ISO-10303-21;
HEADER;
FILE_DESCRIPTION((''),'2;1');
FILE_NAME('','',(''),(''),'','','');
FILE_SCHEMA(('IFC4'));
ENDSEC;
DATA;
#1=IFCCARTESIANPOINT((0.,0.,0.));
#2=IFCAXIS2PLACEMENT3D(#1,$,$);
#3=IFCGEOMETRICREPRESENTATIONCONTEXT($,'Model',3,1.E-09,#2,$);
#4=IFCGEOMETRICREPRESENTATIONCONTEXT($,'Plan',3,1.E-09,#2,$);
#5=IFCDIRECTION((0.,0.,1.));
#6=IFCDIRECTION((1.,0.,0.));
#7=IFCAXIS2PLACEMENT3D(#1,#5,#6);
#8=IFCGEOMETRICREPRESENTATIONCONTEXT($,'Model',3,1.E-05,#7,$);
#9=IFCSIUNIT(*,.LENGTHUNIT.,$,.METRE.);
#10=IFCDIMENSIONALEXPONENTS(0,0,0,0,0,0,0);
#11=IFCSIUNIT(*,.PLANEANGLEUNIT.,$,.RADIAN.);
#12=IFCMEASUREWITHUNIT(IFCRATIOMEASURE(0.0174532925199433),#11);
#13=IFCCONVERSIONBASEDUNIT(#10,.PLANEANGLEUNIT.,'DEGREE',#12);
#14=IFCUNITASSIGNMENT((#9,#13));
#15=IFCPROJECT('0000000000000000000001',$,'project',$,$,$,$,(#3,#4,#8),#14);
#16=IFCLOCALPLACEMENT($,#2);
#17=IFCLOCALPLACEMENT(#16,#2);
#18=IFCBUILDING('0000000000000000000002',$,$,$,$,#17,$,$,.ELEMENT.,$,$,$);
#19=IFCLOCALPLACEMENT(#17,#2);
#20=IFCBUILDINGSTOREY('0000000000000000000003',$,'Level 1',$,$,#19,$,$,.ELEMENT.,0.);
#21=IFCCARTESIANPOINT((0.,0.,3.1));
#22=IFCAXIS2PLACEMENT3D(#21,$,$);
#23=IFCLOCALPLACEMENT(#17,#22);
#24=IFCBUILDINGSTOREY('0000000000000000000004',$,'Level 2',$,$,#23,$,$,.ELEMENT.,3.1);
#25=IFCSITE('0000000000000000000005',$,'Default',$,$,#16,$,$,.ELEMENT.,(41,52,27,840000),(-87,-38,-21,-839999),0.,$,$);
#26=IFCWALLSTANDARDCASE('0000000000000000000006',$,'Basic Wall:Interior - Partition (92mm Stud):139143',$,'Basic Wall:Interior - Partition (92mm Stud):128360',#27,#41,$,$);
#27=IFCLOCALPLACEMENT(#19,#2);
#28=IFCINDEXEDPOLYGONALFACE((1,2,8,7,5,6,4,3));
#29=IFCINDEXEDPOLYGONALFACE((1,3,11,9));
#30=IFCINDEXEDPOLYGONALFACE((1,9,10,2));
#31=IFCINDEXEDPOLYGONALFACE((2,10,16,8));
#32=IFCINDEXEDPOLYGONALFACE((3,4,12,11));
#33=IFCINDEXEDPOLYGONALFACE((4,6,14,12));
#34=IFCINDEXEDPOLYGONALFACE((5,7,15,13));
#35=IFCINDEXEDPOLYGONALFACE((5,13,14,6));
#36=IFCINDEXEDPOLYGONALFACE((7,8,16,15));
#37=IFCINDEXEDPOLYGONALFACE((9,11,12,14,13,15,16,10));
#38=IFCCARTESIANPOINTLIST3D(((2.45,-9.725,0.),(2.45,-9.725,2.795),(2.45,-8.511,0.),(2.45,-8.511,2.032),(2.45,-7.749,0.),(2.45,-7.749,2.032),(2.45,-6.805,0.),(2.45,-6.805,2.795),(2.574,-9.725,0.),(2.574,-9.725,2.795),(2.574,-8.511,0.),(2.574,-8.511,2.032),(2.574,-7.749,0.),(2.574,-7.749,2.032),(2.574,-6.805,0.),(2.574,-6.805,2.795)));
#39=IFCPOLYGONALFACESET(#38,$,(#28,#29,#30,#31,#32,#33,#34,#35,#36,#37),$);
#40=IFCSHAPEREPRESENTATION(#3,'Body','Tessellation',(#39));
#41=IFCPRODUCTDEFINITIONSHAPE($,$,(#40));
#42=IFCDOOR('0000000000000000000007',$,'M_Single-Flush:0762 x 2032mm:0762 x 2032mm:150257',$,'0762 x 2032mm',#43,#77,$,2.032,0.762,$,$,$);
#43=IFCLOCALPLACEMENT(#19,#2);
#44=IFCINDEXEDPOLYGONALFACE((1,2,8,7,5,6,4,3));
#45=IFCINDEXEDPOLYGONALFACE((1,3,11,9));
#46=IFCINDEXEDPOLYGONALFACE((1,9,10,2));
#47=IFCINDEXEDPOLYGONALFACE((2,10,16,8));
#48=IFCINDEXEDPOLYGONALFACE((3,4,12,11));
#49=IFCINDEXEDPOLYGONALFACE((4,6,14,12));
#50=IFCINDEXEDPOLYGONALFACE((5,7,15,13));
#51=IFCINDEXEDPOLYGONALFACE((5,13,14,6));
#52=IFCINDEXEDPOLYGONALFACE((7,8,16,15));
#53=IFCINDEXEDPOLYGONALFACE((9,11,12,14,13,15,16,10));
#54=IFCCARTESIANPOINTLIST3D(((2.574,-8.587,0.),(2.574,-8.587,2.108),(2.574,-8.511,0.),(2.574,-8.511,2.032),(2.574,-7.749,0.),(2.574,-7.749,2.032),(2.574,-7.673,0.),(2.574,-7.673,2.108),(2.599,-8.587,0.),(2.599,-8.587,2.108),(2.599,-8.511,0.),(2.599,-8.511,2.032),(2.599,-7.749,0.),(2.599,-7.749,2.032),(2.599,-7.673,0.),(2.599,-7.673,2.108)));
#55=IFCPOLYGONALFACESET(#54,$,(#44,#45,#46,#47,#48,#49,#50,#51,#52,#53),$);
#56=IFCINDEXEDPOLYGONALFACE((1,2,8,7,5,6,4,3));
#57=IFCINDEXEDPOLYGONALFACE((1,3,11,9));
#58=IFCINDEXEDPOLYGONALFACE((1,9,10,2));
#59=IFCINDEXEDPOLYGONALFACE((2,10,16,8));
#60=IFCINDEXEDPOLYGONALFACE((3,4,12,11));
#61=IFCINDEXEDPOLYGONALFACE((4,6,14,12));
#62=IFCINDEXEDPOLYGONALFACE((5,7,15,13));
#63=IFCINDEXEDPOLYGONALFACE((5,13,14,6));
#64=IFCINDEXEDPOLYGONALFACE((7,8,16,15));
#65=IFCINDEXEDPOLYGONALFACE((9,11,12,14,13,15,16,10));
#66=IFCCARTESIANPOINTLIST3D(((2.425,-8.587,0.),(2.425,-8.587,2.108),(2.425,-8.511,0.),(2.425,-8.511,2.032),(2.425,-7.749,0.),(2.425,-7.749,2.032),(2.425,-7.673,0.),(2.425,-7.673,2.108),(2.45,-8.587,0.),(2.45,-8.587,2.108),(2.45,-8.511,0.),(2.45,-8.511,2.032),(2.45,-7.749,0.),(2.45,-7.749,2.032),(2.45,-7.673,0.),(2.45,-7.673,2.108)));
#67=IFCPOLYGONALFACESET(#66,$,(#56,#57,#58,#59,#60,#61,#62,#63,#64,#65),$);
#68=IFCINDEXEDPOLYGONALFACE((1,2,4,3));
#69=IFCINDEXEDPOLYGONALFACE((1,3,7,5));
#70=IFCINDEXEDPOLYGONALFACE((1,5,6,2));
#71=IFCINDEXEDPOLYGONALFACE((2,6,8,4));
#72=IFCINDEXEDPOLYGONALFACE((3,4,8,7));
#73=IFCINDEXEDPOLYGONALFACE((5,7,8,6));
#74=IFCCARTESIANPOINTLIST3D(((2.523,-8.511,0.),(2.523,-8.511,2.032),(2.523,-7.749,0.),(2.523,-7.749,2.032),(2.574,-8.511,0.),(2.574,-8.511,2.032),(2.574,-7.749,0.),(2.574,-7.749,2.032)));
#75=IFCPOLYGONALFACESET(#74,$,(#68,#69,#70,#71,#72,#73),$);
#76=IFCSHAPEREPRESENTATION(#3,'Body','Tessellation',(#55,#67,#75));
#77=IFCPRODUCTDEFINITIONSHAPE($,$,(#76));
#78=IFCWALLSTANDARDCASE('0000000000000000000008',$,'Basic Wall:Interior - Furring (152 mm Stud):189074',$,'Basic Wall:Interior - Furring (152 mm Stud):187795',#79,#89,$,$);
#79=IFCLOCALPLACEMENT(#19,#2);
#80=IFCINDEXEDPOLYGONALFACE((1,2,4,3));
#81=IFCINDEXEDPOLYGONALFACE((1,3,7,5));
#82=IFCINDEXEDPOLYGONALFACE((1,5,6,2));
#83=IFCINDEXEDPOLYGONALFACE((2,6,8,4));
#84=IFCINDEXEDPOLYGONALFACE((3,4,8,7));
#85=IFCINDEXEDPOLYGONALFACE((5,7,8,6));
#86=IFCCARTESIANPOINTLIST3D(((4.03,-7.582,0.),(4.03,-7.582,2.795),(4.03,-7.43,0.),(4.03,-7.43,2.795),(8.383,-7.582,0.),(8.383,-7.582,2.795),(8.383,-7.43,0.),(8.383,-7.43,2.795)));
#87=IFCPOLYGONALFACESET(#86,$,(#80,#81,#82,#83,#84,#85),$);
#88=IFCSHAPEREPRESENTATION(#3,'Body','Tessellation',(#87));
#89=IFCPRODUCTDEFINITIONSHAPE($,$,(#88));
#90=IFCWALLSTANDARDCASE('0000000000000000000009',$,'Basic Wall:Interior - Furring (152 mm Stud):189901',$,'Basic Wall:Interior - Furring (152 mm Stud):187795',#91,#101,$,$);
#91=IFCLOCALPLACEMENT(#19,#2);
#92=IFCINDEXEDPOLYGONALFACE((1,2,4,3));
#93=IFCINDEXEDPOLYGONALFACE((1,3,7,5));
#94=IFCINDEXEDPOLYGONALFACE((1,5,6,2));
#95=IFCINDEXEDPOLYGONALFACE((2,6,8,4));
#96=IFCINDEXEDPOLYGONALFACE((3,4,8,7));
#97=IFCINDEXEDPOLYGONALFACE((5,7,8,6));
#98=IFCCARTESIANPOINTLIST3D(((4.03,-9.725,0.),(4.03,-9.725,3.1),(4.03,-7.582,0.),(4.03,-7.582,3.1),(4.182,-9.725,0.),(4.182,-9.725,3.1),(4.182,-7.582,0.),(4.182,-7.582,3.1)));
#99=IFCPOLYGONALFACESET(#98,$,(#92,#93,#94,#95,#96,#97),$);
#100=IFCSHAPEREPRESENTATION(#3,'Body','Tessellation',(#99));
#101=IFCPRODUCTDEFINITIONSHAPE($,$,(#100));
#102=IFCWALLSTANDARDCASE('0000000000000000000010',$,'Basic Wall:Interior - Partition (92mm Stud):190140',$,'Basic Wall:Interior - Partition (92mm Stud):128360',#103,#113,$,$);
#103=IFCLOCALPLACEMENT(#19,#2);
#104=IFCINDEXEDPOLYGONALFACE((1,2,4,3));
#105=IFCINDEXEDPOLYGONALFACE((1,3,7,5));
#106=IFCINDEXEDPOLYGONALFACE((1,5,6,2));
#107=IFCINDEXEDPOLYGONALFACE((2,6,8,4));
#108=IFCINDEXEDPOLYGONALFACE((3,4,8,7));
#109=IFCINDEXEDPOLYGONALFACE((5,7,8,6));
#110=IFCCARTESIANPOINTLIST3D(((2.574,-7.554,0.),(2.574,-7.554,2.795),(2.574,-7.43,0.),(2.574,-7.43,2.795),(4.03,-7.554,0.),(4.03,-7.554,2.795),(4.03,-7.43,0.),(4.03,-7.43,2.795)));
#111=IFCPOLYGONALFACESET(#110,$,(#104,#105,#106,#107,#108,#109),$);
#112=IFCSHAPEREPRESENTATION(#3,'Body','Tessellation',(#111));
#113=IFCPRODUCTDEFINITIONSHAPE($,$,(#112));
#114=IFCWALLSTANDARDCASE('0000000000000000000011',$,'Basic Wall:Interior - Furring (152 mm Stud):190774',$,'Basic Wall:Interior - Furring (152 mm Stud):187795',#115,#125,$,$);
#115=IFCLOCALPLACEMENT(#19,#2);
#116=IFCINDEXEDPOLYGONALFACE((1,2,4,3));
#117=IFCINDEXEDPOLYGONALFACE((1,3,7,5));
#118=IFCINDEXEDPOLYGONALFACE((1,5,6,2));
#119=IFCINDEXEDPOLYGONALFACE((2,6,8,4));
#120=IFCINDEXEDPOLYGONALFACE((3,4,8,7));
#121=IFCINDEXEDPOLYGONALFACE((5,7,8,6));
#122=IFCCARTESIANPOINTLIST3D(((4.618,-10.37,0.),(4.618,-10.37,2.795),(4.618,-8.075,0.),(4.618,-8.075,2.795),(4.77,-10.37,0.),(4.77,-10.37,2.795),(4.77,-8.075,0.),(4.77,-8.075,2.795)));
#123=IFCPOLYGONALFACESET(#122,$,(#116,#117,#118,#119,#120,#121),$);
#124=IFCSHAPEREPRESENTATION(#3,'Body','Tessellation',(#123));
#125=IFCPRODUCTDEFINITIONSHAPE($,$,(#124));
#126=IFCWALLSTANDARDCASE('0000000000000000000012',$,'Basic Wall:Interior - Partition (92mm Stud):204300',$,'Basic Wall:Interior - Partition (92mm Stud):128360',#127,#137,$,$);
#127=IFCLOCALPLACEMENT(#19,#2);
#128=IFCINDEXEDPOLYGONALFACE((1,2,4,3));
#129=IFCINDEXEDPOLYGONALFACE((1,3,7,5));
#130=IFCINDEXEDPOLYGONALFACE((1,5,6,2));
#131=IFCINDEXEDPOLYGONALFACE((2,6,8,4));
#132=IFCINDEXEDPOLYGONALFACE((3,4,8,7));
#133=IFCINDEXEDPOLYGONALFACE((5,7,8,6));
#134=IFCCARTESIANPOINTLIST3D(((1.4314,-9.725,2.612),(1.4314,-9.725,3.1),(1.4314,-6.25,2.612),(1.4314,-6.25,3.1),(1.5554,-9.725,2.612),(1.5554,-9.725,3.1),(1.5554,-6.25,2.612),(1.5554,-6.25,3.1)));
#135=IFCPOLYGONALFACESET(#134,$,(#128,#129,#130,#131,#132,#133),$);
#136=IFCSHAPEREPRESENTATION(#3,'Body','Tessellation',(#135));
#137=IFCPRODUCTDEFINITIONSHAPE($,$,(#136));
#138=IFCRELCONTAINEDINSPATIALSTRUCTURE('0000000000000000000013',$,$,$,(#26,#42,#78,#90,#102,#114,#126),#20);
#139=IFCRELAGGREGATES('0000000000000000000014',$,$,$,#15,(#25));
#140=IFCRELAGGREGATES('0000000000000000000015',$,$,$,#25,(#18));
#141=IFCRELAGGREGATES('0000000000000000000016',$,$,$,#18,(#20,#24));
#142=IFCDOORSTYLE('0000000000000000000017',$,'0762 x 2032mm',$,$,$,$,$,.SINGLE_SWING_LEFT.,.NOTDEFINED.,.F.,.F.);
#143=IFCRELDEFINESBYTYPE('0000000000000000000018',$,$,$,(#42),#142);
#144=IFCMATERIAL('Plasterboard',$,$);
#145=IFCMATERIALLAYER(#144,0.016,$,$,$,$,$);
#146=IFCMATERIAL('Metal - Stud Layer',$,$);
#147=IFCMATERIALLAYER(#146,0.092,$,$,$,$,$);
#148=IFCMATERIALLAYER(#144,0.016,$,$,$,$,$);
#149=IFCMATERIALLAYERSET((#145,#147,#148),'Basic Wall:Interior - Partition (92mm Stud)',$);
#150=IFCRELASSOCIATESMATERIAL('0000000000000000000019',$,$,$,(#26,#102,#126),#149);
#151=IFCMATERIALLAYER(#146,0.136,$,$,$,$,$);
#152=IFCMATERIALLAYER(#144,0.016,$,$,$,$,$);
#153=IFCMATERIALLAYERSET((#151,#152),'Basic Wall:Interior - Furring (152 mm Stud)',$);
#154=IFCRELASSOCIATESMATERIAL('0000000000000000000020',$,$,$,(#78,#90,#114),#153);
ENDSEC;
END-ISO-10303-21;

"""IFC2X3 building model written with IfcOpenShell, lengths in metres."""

from ifc_helpers import new_model, entity, si_unit, converted_unit, frame, frame_2d, origin, origin_with_axes, origin_2d_with_axis, place, context, project, spatial, polyline, rectangle, outline, extrude, clip, bounded_halfspace, source, transform, mapped, material, layer, layer_set, layer_usage, type_object, type_shapes, element, fill, save


model = new_model("IFC2X3")

# Units and contexts
model_context_1 = context("Model", 3, precision=1e-09, world=origin())
plan_context = context("Plan", 3, precision=1e-09, world=origin())
model_context_2 = context("Model", 3, precision=1e-05, world=origin_with_axes())
ifc_project = project(units=[si_unit("LENGTHUNIT", "METRE"), converted_unit("PLANEANGLEUNIT", "DEGREE", entity("IfcRatioMeasure", 0.0174532925199433), si_unit("PLANEANGLEUNIT", "RADIAN"), dimensions=[0, 0, 0, 0, 0, 0, 0])], contexts=[model_context_1, plan_context, model_context_2])

# Site, building, storey
site_placement = place(None, origin())
site = spatial("IfcSite", under=ifc_project, at=site_placement, Name="Default", CompositionType="ELEMENT", RefLatitude=(41, 52, 27, 840000), RefLongitude=(-87, -38, -21, -839999), RefElevation=0.0)
building_placement = place(site_placement, origin())
building = spatial("IfcBuilding", under=site, at=building_placement, CompositionType="ELEMENT")
storey_1_placement = place(building_placement, origin())
storey_1 = spatial("IfcBuildingStorey", under=building, at=storey_1_placement, Name="Level 1", CompositionType="ELEMENT", Elevation=0.0)

# Shared definitions
ifc_material_1 = material(Name="Metal - Stud Layer")
ifc_material_2 = material(Name="Plasterboard")

# Shared definitions
ifc_layer_1 = layer(ifc_material_2, 0.016)
ifc_layer_2 = layer(ifc_material_1, 0.092)
ifc_layer_3 = layer(ifc_material_2, 0.016)
ifc_layer_set_1 = layer_set([ifc_layer_1, ifc_layer_2, ifc_layer_3], Name="Basic Wall:Interior - Partition (92mm Stud)")

# Wall, opening, door
ifc_layer_usage_1 = layer_usage(ifc_layer_set_1, "AXIS2", "NEGATIVE", 0.062)
wall_1_placement = place(storey_1_placement, frame((2.512, -6.805, 0.0), z_axis=(0.0, 0.0, 1.0), x_axis=(0.0, -1.0, 0.0)))
wall_1 = element("IfcWallStandardCase", 1, at=wall_1_placement, inside=storey_1, material=ifc_layer_usage_1, Name="Basic Wall:Interior - Partition (92mm Stud):139143", ObjectType="Basic Wall:Interior - Partition (92mm Stud):128360", context=model_context_1, shape_type="SweptSolid", body=[
    extrude(rectangle(XDim=2.92, YDim=0.124, at=frame_2d((1.46, 0.0), x_axis=(-1.0, 0.0))), origin(), (0.0, 0.0, 1.0), 2.795),
])
opening_1_placement = place(wall_1_placement, frame((0.944, -0.062, 0.0)))
opening_1 = element("IfcOpeningElement", 2, at=opening_1_placement, cuts=wall_1, ObjectType="Opening", context=model_context_1, shape_type="SweptSolid", body=[
    extrude(rectangle(XDim=0.762, YDim=2.032, at=frame_2d((1.016, 0.381), x_axis=(0.0, -1.0))), frame((0.0, 0.0, 0.0), z_axis=(0.0, 1.0, 0.0), x_axis=(0.0, 0.0, 1.0)), (0.0, 0.0, 1.0), 0.124),
])
door_style_1 = type_object("IfcDoorStyle", Name="0762 x 2032mm", ConstructionType="NOTDEFINED", OperationType="SINGLE_SWING_LEFT", ParameterTakesPrecedence=False, Sizeable=False)
shared_shape_1 = source(origin(), model_context_1, "Body", "SweptSolid", [
    extrude(outline(polyline([(-0.457, -1.073), (0.457, -1.073), (0.457, 1.035), (0.381, 1.035), (0.381, -0.997), (-0.381, -0.997), (-0.381, 1.035), (-0.457, 1.035), (-0.457, -1.073)])), frame((0.381, 0.149, 1.035), z_axis=(0.0, -1.0, 0.0), x_axis=(-1.0, 0.0, 0.0)), (0.0, 0.0, 1.0), 0.025),
    extrude(outline(polyline([(-1.073, -0.457), (1.035, -0.457), (1.035, -0.381), (-0.997, -0.381), (-0.997, 0.381), (1.035, 0.381), (1.035, 0.457), (-1.073, 0.457), (-1.073, -0.457)])), frame((0.381, 0.0, 1.035), z_axis=(0.0, -1.0, 0.0), x_axis=(0.0, 0.0, -1.0)), (0.0, 0.0, 1.0), 0.025),
    extrude(rectangle(XDim=0.762, YDim=0.051, at=origin_2d_with_axis()), frame((0.381, 0.0985, 0.0)), (0.0, 0.0, 1.0), 2.032),
])
type_shapes(door_style_1, [shared_shape_1])
door_1_placement = place(opening_1_placement, origin())
door_1 = element("IfcDoor", 3, at=door_1_placement, inside=storey_1, type_object=door_style_1, Name="M_Single-Flush:0762 x 2032mm:0762 x 2032mm:150257", ObjectType="0762 x 2032mm", OverallHeight=2.032, OverallWidth=0.762, context=model_context_1, shape_type="MappedRepresentation", body=[
    mapped(shared_shape_1, transform((0.0, 0.0, 0.0), scale=1.0)),
])
fill(opening_1, door_1)

# Shared definitions
storey_2_placement = place(building_placement, frame((0.0, 0.0, 3.1)))
storey_2 = spatial("IfcBuildingStorey", under=building, at=storey_2_placement, Name="Level 2", CompositionType="ELEMENT", Elevation=3.1)

# Walls
ifc_layer_4 = layer(ifc_material_1, 0.136)
ifc_layer_5 = layer(ifc_material_2, 0.016)
ifc_layer_set_2 = layer_set([ifc_layer_4, ifc_layer_5], Name="Basic Wall:Interior - Furring (152 mm Stud)")
ifc_layer_usage_2 = layer_usage(ifc_layer_set_2, "AXIS2", "NEGATIVE", 0.076)
wall_2_placement = place(storey_1_placement, frame((8.383, -7.506, 0.0), z_axis=(0.0, 0.0, 1.0), x_axis=(-1.0, 0.0, 0.0)))
element("IfcWallStandardCase", 4, at=wall_2_placement, inside=storey_1, material=ifc_layer_usage_2, Name="Basic Wall:Interior - Furring (152 mm Stud):189074", ObjectType="Basic Wall:Interior - Furring (152 mm Stud):187795", context=model_context_1, shape_type="Clipping", body=[
    clip(extrude(rectangle(XDim=4.353, YDim=0.152, at=frame_2d((2.1765, 0.0), x_axis=(-1.0, 0.0))), origin(), (0.0, 0.0, 1.0), 2.795), bounded_halfspace(frame((0.0, -0.076, 2.795), z_axis=(0.0, 0.0, -1.0), x_axis=(0.0, 1.0, 0.0)), True, frame((0.0, -0.076, 2.795)), polyline([(0.0, 0.0), (3.708, 0.0), (3.708, 0.152), (0.0, 0.152), (0.0, 0.0)]))),
])
ifc_layer_usage_3 = layer_usage(ifc_layer_set_2, "AXIS2", "POSITIVE", -0.076)
wall_3_placement = place(storey_1_placement, frame((4.106, -9.725, 0.0), z_axis=(0.0, 0.0, 1.0), x_axis=(0.0, 1.0, 0.0)))
element("IfcWallStandardCase", 5, at=wall_3_placement, inside=storey_1, material=ifc_layer_usage_3, Name="Basic Wall:Interior - Furring (152 mm Stud):189901", ObjectType="Basic Wall:Interior - Furring (152 mm Stud):187795", context=model_context_1, shape_type="SweptSolid", body=[
    extrude(rectangle(XDim=2.143, YDim=0.152, at=frame_2d((1.0715, 0.0), x_axis=(-1.0, 0.0))), origin(), (0.0, 0.0, 1.0), 3.1),
])
ifc_layer_usage_4 = layer_usage(ifc_layer_set_1, "AXIS2", "NEGATIVE", 0.062)
wall_4_placement = place(storey_1_placement, frame((4.03, -7.492, 0.0), z_axis=(0.0, 0.0, 1.0), x_axis=(-1.0, 0.0, 0.0)))
element("IfcWallStandardCase", 6, at=wall_4_placement, inside=storey_1, material=ifc_layer_usage_4, Name="Basic Wall:Interior - Partition (92mm Stud):190140", ObjectType="Basic Wall:Interior - Partition (92mm Stud):128360", context=model_context_1, shape_type="SweptSolid", body=[
    extrude(rectangle(XDim=1.456, YDim=0.124, at=frame_2d((0.728, 0.0), x_axis=(-1.0, 0.0))), origin(), (0.0, 0.0, 1.0), 2.795),
])
ifc_layer_usage_5 = layer_usage(ifc_layer_set_2, "AXIS2", "POSITIVE", -0.076)
wall_5_placement = place(storey_1_placement, frame((4.694, -8.075, 0.0), z_axis=(0.0, 0.0, 1.0), x_axis=(0.0, -1.0, 0.0)))
element("IfcWallStandardCase", 7, at=wall_5_placement, inside=storey_1, material=ifc_layer_usage_5, Name="Basic Wall:Interior - Furring (152 mm Stud):190774", ObjectType="Basic Wall:Interior - Furring (152 mm Stud):187795", context=model_context_1, shape_type="SweptSolid", body=[
    extrude(rectangle(XDim=2.295, YDim=0.152, at=frame_2d((1.1475, 0.0), x_axis=(-1.0, 0.0))), origin(), (0.0, 0.0, 1.0), 2.795),
])
ifc_layer_usage_6 = layer_usage(ifc_layer_set_1, "AXIS2", "NEGATIVE", 0.062)
wall_6_placement = place(storey_1_placement, frame((1.4934, -6.25, 2.612), z_axis=(0.0, 0.0, 1.0), x_axis=(0.0, -1.0, 0.0)))
element("IfcWallStandardCase", 8, at=wall_6_placement, inside=storey_1, material=ifc_layer_usage_6, Name="Basic Wall:Interior - Partition (92mm Stud):204300", ObjectType="Basic Wall:Interior - Partition (92mm Stud):128360", context=model_context_1, shape_type="SweptSolid", body=[
    extrude(rectangle(XDim=3.475, YDim=0.124, at=frame_2d((1.7375, 0.0), x_axis=(-1.0, 0.0))), origin(), (0.0, 0.0, 1.0), 0.488),
])

save(model, "model.ifc")
